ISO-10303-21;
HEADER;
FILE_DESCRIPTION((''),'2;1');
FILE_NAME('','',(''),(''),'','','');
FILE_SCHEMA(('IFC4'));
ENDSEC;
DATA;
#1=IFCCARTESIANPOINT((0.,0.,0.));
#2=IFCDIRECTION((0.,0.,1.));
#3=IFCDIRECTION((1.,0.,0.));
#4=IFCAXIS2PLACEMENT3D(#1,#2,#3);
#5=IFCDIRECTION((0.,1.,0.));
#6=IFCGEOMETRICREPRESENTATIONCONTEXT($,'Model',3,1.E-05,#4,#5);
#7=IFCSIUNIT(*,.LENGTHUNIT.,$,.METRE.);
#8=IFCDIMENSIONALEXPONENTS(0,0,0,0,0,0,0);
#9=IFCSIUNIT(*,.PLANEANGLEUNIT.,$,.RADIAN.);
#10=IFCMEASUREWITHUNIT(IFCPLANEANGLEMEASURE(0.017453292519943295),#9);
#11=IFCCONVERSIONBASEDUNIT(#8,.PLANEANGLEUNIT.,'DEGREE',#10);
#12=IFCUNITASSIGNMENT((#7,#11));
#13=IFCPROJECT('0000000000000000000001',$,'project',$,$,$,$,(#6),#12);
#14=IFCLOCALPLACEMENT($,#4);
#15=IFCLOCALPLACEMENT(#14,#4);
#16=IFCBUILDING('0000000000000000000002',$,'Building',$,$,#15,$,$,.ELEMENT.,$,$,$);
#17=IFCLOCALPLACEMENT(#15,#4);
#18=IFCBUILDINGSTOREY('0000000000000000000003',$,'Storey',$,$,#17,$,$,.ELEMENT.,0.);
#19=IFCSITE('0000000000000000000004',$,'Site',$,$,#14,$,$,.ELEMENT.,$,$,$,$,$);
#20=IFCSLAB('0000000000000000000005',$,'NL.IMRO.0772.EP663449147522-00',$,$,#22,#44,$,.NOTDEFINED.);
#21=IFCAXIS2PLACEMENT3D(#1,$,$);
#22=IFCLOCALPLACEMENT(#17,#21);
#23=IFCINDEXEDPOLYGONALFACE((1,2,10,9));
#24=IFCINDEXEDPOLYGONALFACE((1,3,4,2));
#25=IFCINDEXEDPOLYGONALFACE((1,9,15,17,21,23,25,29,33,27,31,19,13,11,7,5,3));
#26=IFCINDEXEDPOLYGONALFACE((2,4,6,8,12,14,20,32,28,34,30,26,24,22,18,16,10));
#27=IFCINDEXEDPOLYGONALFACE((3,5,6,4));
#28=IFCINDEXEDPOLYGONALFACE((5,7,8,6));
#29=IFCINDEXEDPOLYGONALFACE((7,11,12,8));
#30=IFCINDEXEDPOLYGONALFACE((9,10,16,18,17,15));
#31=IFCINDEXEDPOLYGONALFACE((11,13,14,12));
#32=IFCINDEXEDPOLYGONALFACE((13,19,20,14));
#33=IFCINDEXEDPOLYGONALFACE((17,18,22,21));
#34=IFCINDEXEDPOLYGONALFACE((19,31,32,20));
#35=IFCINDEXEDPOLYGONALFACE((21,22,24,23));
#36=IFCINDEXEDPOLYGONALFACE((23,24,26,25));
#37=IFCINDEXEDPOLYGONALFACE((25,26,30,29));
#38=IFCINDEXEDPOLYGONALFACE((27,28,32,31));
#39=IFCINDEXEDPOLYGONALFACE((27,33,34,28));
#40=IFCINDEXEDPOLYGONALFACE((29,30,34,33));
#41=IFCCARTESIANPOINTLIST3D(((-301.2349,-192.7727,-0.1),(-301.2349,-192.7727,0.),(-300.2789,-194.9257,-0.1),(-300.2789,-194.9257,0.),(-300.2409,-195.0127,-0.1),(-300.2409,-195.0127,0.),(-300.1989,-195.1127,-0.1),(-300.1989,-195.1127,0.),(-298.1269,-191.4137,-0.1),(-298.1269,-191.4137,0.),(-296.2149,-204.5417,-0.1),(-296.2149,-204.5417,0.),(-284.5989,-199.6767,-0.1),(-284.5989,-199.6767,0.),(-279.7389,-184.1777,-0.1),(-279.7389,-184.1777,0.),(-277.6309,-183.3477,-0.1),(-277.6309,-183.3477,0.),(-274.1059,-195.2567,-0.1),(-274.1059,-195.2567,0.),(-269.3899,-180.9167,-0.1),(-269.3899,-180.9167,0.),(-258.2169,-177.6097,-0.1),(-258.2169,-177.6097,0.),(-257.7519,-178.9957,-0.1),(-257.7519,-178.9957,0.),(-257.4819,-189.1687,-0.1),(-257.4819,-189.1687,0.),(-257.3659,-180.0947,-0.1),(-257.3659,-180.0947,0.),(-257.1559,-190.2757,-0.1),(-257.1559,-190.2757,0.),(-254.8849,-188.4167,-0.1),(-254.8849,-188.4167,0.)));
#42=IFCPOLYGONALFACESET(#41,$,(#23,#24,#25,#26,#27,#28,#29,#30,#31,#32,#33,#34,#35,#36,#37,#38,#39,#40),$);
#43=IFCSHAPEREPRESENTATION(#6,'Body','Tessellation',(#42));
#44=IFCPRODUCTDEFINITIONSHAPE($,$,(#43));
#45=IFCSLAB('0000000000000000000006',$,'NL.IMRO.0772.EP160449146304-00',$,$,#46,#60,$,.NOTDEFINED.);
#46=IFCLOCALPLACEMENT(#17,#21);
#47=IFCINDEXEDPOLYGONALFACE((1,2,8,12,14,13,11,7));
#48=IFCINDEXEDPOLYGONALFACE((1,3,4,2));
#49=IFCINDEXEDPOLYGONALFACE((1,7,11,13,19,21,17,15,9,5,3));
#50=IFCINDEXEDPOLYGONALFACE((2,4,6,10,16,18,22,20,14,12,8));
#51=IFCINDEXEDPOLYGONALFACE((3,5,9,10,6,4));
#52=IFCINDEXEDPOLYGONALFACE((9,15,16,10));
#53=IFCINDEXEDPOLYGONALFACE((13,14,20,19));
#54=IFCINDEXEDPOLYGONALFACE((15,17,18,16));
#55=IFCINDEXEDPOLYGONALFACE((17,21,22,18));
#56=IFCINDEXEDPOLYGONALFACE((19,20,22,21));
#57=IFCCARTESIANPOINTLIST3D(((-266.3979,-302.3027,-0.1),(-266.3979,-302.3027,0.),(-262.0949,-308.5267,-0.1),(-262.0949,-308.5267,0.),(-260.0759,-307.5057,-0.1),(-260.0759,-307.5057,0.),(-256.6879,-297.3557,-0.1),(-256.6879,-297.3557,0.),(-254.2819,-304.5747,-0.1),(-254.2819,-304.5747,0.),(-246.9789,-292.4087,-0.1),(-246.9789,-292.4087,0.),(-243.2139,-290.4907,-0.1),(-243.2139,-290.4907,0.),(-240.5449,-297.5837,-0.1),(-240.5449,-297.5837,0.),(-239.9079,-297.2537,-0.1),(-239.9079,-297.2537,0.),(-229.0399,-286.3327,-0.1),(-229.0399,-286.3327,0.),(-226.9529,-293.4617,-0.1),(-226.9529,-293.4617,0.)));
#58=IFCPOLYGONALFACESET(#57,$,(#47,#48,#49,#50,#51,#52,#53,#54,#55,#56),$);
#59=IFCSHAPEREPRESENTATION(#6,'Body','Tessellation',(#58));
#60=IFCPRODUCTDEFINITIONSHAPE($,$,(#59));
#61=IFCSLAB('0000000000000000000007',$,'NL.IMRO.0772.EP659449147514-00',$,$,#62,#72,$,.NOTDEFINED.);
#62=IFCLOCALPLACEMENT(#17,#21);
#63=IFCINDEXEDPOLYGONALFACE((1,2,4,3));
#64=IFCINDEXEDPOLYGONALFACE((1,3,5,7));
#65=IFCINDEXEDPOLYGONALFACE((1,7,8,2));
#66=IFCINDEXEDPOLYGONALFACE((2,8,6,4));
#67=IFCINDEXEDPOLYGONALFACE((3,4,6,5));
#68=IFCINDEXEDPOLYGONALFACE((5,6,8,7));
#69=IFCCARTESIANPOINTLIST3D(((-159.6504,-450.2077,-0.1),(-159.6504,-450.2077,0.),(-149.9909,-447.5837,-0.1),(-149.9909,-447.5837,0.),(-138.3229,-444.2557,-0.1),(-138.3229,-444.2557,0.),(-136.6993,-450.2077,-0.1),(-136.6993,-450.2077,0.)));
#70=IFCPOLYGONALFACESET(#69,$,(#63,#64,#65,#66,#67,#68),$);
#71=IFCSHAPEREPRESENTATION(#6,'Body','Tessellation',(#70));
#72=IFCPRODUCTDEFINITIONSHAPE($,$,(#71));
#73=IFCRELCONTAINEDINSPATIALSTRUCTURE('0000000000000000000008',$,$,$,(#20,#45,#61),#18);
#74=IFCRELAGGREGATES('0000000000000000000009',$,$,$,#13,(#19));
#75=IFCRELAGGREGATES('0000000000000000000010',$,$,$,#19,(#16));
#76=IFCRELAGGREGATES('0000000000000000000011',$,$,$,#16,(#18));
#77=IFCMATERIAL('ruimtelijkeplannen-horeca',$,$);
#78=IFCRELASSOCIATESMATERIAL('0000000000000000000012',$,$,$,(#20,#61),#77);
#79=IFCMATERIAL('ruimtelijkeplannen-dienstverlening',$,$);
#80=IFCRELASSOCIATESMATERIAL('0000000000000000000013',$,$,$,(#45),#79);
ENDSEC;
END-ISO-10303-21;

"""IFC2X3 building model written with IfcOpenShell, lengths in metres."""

from ifc_helpers import new_model, entity, si_unit, converted_unit, direction, frame, origin_with_axes, place, context, project, spatial, polyline, outline, extrude, material, element, save


model = new_model("IFC2X3")

# Units and contexts
model_context = context("Model", 3, precision=1e-05, world=origin_with_axes(), true_north=direction((0.0, 1.0, 0.0)))
ifc_project = project(units=[si_unit("LENGTHUNIT", "METRE"), converted_unit("PLANEANGLEUNIT", "DEGREE", entity("IfcPlaneAngleMeasure", 0.017453292519943295), si_unit("PLANEANGLEUNIT", "RADIAN"), dimensions=[0, 0, 0, 0, 0, 0, 0])], contexts=[model_context])

# Site, building, storey
site_placement = place(None, origin_with_axes())
site = spatial("IfcSite", under=ifc_project, at=site_placement, Name="Site", CompositionType="ELEMENT")
building_placement = place(site_placement, origin_with_axes())
building = spatial("IfcBuilding", under=site, at=building_placement, Name="Building", CompositionType="ELEMENT")
storey_placement = place(building_placement, origin_with_axes())
storey = spatial("IfcBuildingStorey", under=building, at=storey_placement, Name="Storey", CompositionType="ELEMENT", Elevation=0.0)

# Slabs
ifc_material_1 = material(Name="ruimtelijkeplannen-horeca")
slab_1_placement = place(storey_placement, frame((0.0, 0.0, -0.1), z_axis=(0.0, 0.0, 1.0), x_axis=(1.0, 0.0, 0.0)))
element("IfcSlab", 1, at=slab_1_placement, inside=storey, material=ifc_material_1, Name="NL.IMRO.0772.EP663449147522-00", PredefinedType="NOTDEFINED", context=model_context, shape_type="SweptSolid", body=[
    extrude(outline(polyline([(-300.2409, -195.0127), (-300.2789, -194.9257), (-301.2349, -192.7727), (-298.1269, -191.4137), (-279.7389, -184.1777), (-277.6309, -183.3477), (-269.3899, -180.9167), (-258.2169, -177.6097), (-257.7519, -178.9957), (-257.3659, -180.0947), (-254.8849, -188.4167), (-257.4819, -189.1687), (-257.1559, -190.2757), (-274.1059, -195.2567), (-284.5989, -199.6767), (-296.2149, -204.5417), (-300.1989, -195.1127), (-300.2409, -195.0127)])), origin_with_axes(), (0.0, 0.0, 1.0), 0.1),
])
ifc_material_2 = material(Name="ruimtelijkeplannen-dienstverlening")
slab_2_placement = place(storey_placement, frame((0.0, 0.0, -0.1), z_axis=(0.0, 0.0, 1.0), x_axis=(1.0, 0.0, 0.0)))
element("IfcSlab", 2, at=slab_2_placement, inside=storey, material=ifc_material_2, Name="NL.IMRO.0772.EP160449146304-00", PredefinedType="NOTDEFINED", context=model_context, shape_type="SweptSolid", body=[
    extrude(outline(polyline([(-239.9079, -297.2537), (-240.5449, -297.5837), (-254.2819, -304.5747), (-260.0759, -307.5057), (-262.0949, -308.5267), (-266.3979, -302.3027), (-256.6879, -297.3557), (-246.9789, -292.4087), (-243.2139, -290.4907), (-229.0399, -286.3327), (-226.9529, -293.4617), (-239.9079, -297.2537)])), origin_with_axes(), (0.0, 0.0, 1.0), 0.1),
])
slab_3_placement = place(storey_placement, frame((0.0, 0.0, -0.1), z_axis=(0.0, 0.0, 1.0), x_axis=(1.0, 0.0, 0.0)))
element("IfcSlab", 3, at=slab_3_placement, inside=storey, material=ifc_material_1, Name="NL.IMRO.0772.EP659449147514-00", PredefinedType="NOTDEFINED", context=model_context, shape_type="SweptSolid", body=[
    extrude(outline(polyline([(-149.9909, -447.5837), (-138.3229, -444.2557), (-136.6993, -450.2077), (-159.6504, -450.2077), (-149.9909, -447.5837)])), origin_with_axes(), (0.0, 0.0, 1.0), 0.1),
])

save(model, "model.ifc")
